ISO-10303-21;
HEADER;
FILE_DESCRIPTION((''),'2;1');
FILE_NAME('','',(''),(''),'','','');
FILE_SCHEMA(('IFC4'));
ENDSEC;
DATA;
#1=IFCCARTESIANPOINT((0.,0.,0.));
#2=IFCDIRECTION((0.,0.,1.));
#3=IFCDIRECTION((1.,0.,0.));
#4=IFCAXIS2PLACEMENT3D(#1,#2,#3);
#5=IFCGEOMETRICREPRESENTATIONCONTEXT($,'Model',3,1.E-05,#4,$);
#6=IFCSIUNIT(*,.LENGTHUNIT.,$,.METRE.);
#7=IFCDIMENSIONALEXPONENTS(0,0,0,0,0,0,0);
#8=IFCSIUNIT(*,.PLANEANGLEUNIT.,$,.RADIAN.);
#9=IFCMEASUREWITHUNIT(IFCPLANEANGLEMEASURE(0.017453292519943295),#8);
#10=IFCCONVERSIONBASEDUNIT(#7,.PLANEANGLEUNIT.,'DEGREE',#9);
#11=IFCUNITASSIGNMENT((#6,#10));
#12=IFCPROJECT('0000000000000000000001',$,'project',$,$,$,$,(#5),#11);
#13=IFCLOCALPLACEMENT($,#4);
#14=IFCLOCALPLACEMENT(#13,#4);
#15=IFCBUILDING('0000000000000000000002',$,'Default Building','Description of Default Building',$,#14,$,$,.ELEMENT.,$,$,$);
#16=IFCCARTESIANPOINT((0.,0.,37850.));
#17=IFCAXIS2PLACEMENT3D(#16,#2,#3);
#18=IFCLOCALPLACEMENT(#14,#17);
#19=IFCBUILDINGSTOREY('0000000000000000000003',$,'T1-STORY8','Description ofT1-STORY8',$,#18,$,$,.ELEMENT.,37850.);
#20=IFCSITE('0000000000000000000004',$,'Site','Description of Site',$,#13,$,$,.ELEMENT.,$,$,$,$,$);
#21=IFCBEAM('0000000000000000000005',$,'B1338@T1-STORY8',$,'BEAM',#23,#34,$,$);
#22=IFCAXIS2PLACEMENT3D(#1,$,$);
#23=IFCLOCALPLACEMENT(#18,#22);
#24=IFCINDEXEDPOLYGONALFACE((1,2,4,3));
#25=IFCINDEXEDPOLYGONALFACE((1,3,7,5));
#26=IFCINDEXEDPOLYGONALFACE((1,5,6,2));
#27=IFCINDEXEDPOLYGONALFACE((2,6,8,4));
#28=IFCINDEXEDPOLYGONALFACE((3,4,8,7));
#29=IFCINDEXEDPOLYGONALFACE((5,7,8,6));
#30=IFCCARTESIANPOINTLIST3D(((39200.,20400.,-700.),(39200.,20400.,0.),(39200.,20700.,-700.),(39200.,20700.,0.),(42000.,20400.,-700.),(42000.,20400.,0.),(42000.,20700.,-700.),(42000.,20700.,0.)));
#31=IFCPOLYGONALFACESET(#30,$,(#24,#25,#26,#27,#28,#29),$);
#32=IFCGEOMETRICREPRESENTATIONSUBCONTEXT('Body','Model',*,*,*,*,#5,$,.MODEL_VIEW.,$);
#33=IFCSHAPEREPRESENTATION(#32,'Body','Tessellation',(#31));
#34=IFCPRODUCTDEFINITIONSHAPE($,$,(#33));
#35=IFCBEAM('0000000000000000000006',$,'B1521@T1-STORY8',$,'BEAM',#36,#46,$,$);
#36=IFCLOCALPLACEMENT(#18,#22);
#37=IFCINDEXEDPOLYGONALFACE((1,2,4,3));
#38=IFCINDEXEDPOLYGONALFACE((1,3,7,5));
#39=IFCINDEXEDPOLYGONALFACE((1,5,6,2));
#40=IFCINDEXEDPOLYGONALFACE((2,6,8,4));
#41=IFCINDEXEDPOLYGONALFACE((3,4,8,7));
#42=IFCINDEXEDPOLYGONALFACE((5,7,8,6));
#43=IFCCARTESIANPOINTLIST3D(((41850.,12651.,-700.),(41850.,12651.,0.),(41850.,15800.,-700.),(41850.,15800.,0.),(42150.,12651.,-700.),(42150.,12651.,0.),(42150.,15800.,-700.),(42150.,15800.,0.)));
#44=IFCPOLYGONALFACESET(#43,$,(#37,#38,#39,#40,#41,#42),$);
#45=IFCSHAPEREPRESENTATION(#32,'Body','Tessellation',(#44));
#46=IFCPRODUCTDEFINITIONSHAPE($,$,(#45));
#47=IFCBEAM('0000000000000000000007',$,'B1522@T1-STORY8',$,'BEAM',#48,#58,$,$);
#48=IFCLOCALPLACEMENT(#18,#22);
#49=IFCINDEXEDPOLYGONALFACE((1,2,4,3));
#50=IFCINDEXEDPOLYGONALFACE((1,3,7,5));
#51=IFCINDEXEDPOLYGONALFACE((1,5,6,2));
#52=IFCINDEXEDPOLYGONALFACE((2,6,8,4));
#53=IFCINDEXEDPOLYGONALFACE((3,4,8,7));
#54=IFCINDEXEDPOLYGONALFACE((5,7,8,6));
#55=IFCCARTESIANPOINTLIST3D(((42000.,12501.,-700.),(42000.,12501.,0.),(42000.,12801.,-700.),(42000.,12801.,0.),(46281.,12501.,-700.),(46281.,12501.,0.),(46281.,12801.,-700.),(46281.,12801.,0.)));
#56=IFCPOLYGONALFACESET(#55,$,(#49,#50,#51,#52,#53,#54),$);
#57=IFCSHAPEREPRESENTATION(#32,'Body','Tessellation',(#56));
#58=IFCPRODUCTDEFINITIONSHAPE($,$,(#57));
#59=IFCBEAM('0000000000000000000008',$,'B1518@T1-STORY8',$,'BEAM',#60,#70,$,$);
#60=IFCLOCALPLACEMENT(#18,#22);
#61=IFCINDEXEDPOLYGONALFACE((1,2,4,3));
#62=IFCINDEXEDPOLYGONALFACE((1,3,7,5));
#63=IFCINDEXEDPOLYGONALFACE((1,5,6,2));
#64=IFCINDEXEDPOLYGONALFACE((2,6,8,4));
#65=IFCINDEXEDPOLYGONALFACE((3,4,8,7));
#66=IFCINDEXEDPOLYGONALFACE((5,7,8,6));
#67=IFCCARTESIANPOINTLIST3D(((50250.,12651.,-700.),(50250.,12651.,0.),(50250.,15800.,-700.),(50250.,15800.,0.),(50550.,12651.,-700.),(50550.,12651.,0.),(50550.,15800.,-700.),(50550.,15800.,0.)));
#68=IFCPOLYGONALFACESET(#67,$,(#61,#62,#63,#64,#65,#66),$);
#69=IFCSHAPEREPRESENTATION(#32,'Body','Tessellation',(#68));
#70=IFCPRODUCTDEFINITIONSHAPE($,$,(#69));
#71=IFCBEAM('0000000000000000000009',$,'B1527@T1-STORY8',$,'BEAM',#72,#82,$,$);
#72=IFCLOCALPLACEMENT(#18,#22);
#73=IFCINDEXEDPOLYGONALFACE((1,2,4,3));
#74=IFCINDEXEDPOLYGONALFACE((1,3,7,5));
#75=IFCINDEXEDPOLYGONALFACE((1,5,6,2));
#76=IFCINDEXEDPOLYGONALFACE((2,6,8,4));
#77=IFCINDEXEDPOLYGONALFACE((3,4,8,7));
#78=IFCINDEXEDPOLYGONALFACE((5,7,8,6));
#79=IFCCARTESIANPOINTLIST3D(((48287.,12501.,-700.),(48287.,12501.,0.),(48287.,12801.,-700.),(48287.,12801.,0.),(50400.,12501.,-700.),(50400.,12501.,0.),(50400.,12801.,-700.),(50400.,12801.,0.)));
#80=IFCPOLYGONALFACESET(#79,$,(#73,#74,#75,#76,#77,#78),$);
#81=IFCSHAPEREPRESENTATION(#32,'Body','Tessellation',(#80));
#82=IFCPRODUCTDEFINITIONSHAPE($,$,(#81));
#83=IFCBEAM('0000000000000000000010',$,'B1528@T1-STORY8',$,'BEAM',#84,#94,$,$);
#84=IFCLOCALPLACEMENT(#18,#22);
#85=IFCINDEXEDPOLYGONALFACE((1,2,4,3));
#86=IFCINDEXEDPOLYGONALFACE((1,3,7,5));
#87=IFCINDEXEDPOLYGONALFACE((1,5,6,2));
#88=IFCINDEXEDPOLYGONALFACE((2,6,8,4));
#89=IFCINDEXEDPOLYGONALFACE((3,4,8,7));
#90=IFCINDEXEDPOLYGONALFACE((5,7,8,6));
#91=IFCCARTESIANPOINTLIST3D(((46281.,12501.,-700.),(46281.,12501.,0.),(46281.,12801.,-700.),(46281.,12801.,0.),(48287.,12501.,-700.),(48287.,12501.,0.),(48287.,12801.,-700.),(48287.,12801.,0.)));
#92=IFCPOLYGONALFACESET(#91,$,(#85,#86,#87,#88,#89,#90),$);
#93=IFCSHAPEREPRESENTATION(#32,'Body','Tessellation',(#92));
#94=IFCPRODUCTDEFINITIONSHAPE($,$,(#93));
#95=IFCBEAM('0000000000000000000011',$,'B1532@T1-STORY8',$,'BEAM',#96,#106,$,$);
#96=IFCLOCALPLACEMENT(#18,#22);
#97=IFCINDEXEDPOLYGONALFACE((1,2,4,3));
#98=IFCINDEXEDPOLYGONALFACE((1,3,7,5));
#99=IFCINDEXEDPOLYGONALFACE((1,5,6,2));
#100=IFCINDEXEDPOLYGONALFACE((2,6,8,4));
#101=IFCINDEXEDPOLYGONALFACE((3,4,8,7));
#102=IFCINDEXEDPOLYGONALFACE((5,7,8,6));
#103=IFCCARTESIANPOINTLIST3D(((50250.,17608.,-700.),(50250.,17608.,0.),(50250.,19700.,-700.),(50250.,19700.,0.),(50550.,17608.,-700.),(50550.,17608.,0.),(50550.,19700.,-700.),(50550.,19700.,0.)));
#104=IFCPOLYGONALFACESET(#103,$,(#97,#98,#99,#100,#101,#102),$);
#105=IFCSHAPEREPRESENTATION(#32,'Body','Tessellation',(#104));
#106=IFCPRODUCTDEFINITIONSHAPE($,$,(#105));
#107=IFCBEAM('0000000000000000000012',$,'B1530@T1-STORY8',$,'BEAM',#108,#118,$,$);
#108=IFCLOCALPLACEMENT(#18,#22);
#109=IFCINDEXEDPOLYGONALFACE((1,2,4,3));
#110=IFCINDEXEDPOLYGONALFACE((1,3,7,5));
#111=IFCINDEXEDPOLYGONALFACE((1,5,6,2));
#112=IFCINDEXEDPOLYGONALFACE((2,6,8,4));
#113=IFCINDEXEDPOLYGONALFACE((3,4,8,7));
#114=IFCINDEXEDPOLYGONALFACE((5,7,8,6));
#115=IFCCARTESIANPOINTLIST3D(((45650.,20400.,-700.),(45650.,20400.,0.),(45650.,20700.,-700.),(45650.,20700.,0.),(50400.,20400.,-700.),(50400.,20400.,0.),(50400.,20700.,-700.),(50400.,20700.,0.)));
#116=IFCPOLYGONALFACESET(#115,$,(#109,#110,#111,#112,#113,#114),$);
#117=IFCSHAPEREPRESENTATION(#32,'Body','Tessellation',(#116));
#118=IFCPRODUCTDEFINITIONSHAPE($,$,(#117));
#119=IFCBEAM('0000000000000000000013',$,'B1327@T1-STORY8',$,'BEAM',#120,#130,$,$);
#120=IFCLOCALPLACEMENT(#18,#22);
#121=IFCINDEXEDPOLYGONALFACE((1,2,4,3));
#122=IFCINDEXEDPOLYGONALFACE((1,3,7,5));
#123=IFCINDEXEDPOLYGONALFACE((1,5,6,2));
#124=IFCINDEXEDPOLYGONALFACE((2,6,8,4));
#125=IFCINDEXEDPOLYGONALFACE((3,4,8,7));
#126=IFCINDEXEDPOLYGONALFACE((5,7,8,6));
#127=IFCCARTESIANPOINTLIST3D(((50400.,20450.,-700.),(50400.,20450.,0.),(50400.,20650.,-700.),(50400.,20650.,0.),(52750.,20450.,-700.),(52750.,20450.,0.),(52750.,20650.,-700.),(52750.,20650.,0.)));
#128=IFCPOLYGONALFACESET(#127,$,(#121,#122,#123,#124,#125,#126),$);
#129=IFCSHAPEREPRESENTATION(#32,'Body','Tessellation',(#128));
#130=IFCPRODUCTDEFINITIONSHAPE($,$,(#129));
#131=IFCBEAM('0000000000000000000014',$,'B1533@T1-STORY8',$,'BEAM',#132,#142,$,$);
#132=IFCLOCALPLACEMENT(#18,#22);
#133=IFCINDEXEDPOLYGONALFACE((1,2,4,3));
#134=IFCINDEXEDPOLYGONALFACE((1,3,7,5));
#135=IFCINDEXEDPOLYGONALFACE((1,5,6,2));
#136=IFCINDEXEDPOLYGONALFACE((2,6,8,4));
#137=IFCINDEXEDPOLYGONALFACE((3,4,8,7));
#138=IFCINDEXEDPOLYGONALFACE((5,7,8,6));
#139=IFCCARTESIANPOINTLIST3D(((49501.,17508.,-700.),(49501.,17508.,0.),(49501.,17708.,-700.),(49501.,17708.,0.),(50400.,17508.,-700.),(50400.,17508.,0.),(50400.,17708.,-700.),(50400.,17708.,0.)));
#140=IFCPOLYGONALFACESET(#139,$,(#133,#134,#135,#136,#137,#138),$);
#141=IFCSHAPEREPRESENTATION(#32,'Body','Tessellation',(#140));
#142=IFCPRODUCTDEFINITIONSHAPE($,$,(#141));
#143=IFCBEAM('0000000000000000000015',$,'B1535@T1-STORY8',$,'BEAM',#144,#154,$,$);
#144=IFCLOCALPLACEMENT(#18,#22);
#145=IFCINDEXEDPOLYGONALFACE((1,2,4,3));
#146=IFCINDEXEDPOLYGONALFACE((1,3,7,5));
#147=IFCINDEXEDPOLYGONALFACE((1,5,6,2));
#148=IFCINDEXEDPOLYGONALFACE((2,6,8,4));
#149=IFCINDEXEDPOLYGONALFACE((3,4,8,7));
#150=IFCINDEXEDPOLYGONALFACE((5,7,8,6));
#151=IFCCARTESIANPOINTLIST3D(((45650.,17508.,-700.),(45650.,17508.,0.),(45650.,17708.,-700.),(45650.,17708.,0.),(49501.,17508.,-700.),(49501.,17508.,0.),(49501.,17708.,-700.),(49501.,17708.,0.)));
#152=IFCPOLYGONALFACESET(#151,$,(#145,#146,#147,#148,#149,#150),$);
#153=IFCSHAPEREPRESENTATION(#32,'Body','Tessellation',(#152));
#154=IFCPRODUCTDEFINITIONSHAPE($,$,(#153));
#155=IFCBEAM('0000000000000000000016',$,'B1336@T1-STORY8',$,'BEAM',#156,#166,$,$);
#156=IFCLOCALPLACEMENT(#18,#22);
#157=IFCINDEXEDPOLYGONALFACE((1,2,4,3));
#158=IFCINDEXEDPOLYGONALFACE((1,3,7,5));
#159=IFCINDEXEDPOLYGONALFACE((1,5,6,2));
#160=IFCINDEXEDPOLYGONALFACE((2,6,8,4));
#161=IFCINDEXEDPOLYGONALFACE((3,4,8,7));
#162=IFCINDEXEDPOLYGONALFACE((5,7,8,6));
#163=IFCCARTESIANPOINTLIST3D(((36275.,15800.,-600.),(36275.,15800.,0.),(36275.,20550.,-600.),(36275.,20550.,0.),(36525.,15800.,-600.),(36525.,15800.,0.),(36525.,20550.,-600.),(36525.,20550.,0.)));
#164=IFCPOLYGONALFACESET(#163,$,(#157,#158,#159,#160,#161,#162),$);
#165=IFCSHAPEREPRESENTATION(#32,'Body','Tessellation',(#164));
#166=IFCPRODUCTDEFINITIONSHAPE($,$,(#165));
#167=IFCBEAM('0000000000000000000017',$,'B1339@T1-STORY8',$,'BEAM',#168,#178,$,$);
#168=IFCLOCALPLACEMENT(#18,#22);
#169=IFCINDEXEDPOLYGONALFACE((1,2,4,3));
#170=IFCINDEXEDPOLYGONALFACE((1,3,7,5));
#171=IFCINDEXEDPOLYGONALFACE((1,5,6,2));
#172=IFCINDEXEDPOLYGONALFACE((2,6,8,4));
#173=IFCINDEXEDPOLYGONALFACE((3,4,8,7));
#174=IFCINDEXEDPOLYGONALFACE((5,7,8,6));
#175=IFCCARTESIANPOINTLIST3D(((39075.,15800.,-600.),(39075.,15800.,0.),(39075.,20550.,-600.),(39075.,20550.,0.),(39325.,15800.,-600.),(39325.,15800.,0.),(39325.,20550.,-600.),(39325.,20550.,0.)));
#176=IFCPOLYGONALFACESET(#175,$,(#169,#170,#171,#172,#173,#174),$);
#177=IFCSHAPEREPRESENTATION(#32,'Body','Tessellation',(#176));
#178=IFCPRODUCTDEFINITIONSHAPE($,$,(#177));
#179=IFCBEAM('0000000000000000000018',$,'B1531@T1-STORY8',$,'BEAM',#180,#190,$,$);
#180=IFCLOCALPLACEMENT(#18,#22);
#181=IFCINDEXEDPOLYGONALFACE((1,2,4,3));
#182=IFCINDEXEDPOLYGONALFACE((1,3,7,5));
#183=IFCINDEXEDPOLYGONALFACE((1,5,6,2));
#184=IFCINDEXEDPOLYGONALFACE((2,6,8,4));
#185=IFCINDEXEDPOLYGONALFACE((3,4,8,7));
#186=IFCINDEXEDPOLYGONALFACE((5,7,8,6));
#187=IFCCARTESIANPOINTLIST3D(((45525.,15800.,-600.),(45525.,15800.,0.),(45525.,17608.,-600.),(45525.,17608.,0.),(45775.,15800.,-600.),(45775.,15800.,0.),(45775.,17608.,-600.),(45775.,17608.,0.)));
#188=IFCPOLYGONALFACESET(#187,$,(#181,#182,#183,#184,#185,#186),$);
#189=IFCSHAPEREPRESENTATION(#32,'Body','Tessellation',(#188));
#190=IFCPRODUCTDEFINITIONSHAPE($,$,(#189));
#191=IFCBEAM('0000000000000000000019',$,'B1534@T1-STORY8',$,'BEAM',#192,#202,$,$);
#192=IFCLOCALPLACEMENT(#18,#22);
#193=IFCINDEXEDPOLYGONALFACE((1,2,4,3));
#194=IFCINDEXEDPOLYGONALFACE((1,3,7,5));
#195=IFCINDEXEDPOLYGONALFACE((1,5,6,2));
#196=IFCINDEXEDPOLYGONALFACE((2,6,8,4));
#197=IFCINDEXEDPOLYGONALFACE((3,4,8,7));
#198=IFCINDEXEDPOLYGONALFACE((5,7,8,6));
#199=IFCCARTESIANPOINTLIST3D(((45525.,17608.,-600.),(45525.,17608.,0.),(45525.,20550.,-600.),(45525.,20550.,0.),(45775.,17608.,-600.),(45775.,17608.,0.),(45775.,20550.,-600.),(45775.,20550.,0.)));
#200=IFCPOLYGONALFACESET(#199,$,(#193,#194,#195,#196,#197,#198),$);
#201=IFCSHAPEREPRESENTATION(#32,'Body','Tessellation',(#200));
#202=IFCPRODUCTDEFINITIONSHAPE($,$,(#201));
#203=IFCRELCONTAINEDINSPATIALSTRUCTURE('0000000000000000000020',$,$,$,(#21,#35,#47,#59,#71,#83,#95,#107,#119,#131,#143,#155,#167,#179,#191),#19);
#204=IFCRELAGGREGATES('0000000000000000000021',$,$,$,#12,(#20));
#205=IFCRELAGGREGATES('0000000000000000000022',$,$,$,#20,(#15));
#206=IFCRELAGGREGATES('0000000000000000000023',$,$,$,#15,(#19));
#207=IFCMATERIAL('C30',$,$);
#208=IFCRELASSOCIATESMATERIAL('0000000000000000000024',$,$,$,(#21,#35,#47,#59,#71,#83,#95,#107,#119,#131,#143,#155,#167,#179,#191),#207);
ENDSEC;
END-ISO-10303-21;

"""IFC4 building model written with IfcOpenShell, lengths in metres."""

from ifc_helpers import new_model, entity, si_unit, converted_unit, frame, origin_with_axes, place, context, subcontext, project, spatial, rectangle, extrude, material, element, save


model = new_model("IFC4")

# Units and contexts
model_context = context("Model", 3, precision=1e-05, world=origin_with_axes())
body_context = subcontext(model_context, "Body", "Model", "MODEL_VIEW")
ifc_project = project(units=[si_unit("LENGTHUNIT", "METRE"), converted_unit("PLANEANGLEUNIT", "DEGREE", entity("IfcPlaneAngleMeasure", 0.017453292519943295), si_unit("PLANEANGLEUNIT", "RADIAN"), dimensions=[0, 0, 0, 0, 0, 0, 0])], contexts=[model_context])

# Site, building, storey
site_placement = place(None, origin_with_axes())
site = spatial("IfcSite", under=ifc_project, at=site_placement, Name="Site", Description="Description of Site", CompositionType="ELEMENT")
building_placement = place(site_placement, origin_with_axes())
building = spatial("IfcBuilding", under=site, at=building_placement, Name="Default Building", Description="Description of Default Building", CompositionType="ELEMENT")
storey_placement = place(building_placement, frame((0.0, 0.0, 37850.0), z_axis=(0.0, 0.0, 1.0), x_axis=(1.0, 0.0, 0.0)))
storey = spatial("IfcBuildingStorey", under=building, at=storey_placement, Name="T1-STORY8", Description="Description ofT1-STORY8", CompositionType="ELEMENT", Elevation=37850.0)

# Beams
ifc_material_1 = material(Name="C30")
for number, where, z_axis, x_axis, name in (
    (1, (39200.0, 20550.0, -350.0), (1.0, 0.0, 0.0), (0.0, 1.0, 0.0), "B1338@T1-STORY8"),
):
    element("IfcBeam", number, at=place(storey_placement, frame(where, z_axis=z_axis, x_axis=x_axis)), inside=storey, material=ifc_material_1, Name=name, ObjectType="BEAM", context=body_context, shape_type="SweptSolid", body=[
        extrude(rectangle(XDim=300.0, YDim=700.0), origin_with_axes(), (0.0, 0.0, 1.0), 2800.0),
    ])
beam_1_placement = place(storey_placement, frame((42000.0, 12651.0, -350.0), z_axis=(0.0, 1.0, 0.0), x_axis=(-1.0, 0.0, 0.0)))
element("IfcBeam", 2, at=beam_1_placement, inside=storey, material=ifc_material_1, Name="B1521@T1-STORY8", ObjectType="BEAM", context=body_context, shape_type="SweptSolid", body=[
    extrude(rectangle(XDim=300.0, YDim=700.0), origin_with_axes(), (0.0, 0.0, 1.0), 3149.0),
])
beam_2_placement = place(storey_placement, frame((42000.0, 12651.0, -350.0), z_axis=(1.0, 0.0, 0.0), x_axis=(0.0, 1.0, 0.0)))
element("IfcBeam", 3, at=beam_2_placement, inside=storey, material=ifc_material_1, Name="B1522@T1-STORY8", ObjectType="BEAM", context=body_context, shape_type="SweptSolid", body=[
    extrude(rectangle(XDim=300.0, YDim=700.0), origin_with_axes(), (0.0, 0.0, 1.0), 4281.0),
])
beam_3_placement = place(storey_placement, frame((50400.0, 12651.0, -350.0), z_axis=(0.0, 1.0, 0.0), x_axis=(-1.0, 0.0, 0.0)))
element("IfcBeam", 4, at=beam_3_placement, inside=storey, material=ifc_material_1, Name="B1518@T1-STORY8", ObjectType="BEAM", context=body_context, shape_type="SweptSolid", body=[
    extrude(rectangle(XDim=300.0, YDim=700.0), origin_with_axes(), (0.0, 0.0, 1.0), 3149.0),
])
beam_4_placement = place(storey_placement, frame((48287.0, 12651.0, -350.0), z_axis=(1.0, 0.0, 0.0), x_axis=(0.0, 1.0, 0.0)))
element("IfcBeam", 5, at=beam_4_placement, inside=storey, material=ifc_material_1, Name="B1527@T1-STORY8", ObjectType="BEAM", context=body_context, shape_type="SweptSolid", body=[
    extrude(rectangle(XDim=300.0, YDim=700.0), origin_with_axes(), (0.0, 0.0, 1.0), 2113.0),
])
beam_5_placement = place(storey_placement, frame((46281.0, 12651.0, -350.0), z_axis=(1.0, 0.0, 0.0), x_axis=(0.0, 1.0, 0.0)))
element("IfcBeam", 6, at=beam_5_placement, inside=storey, material=ifc_material_1, Name="B1528@T1-STORY8", ObjectType="BEAM", context=body_context, shape_type="SweptSolid", body=[
    extrude(rectangle(XDim=300.0, YDim=700.0), origin_with_axes(), (0.0, 0.0, 1.0), 2006.0),
])
beam_6_placement = place(storey_placement, frame((50400.0, 17608.0, -350.0), z_axis=(0.0, 1.0, 0.0), x_axis=(-1.0, 0.0, 0.0)))
element("IfcBeam", 7, at=beam_6_placement, inside=storey, material=ifc_material_1, Name="B1532@T1-STORY8", ObjectType="BEAM", context=body_context, shape_type="SweptSolid", body=[
    extrude(rectangle(XDim=300.0, YDim=700.0), origin_with_axes(), (0.0, 0.0, 1.0), 2092.0),
])
beam_7_placement = place(storey_placement, frame((45650.0, 20550.0, -350.0), z_axis=(1.0, 0.0, 0.0), x_axis=(0.0, 1.0, 0.0)))
element("IfcBeam", 8, at=beam_7_placement, inside=storey, material=ifc_material_1, Name="B1530@T1-STORY8", ObjectType="BEAM", context=body_context, shape_type="SweptSolid", body=[
    extrude(rectangle(XDim=300.0, YDim=700.0), origin_with_axes(), (0.0, 0.0, 1.0), 4750.0),
])
beam_8_placement = place(storey_placement, frame((50400.0, 20550.0, -350.0), z_axis=(1.0, 0.0, 0.0), x_axis=(0.0, 1.0, 0.0)))
element("IfcBeam", 9, at=beam_8_placement, inside=storey, material=ifc_material_1, Name="B1327@T1-STORY8", ObjectType="BEAM", context=body_context, shape_type="SweptSolid", body=[
    extrude(rectangle(XDim=200.0, YDim=700.0), origin_with_axes(), (0.0, 0.0, 1.0), 2350.0),
])
beam_9_placement = place(storey_placement, frame((49501.0, 17608.0, -350.0), z_axis=(1.0, 0.0, 0.0), x_axis=(0.0, 1.0, 0.0)))
element("IfcBeam", 10, at=beam_9_placement, inside=storey, material=ifc_material_1, Name="B1533@T1-STORY8", ObjectType="BEAM", context=body_context, shape_type="SweptSolid", body=[
    extrude(rectangle(XDim=200.0, YDim=700.0), origin_with_axes(), (0.0, 0.0, 1.0), 899.0),
])
beam_10_placement = place(storey_placement, frame((45650.0, 17608.0, -350.0), z_axis=(1.0, 0.0, 0.0), x_axis=(0.0, 1.0, 0.0)))
element("IfcBeam", 11, at=beam_10_placement, inside=storey, material=ifc_material_1, Name="B1535@T1-STORY8", ObjectType="BEAM", context=body_context, shape_type="SweptSolid", body=[
    extrude(rectangle(XDim=200.0, YDim=700.0), origin_with_axes(), (0.0, 0.0, 1.0), 3851.0),
])
for number, where, z_axis, x_axis, name in (
    (12, (36400.0, 15800.0, -300.0), (0.0, 1.0, 0.0), (-1.0, 0.0, 0.0), "B1336@T1-STORY8"),
    (13, (39200.0, 15800.0, -300.0), (0.0, 1.0, 0.0), (-1.0, 0.0, 0.0), "B1339@T1-STORY8"),
):
    element("IfcBeam", number, at=place(storey_placement, frame(where, z_axis=z_axis, x_axis=x_axis)), inside=storey, material=ifc_material_1, Name=name, ObjectType="BEAM", context=body_context, shape_type="SweptSolid", body=[
        extrude(rectangle(XDim=250.0, YDim=600.0), origin_with_axes(), (0.0, 0.0, 1.0), 4750.0),
    ])
beam_11_placement = place(storey_placement, frame((45650.0, 15800.0, -300.0), z_axis=(0.0, 1.0, 0.0), x_axis=(-1.0, 0.0, 0.0)))
element("IfcBeam", 14, at=beam_11_placement, inside=storey, material=ifc_material_1, Name="B1531@T1-STORY8", ObjectType="BEAM", context=body_context, shape_type="SweptSolid", body=[
    extrude(rectangle(XDim=250.0, YDim=600.0), origin_with_axes(), (0.0, 0.0, 1.0), 1808.0),
])
beam_12_placement = place(storey_placement, frame((45650.0, 17608.0, -300.0), z_axis=(0.0, 1.0, 0.0), x_axis=(-1.0, 0.0, 0.0)))
element("IfcBeam", 15, at=beam_12_placement, inside=storey, material=ifc_material_1, Name="B1534@T1-STORY8", ObjectType="BEAM", context=body_context, shape_type="SweptSolid", body=[
    extrude(rectangle(XDim=250.0, YDim=600.0), origin_with_axes(), (0.0, 0.0, 1.0), 2942.0),
])

save(model, "model.ifc")
